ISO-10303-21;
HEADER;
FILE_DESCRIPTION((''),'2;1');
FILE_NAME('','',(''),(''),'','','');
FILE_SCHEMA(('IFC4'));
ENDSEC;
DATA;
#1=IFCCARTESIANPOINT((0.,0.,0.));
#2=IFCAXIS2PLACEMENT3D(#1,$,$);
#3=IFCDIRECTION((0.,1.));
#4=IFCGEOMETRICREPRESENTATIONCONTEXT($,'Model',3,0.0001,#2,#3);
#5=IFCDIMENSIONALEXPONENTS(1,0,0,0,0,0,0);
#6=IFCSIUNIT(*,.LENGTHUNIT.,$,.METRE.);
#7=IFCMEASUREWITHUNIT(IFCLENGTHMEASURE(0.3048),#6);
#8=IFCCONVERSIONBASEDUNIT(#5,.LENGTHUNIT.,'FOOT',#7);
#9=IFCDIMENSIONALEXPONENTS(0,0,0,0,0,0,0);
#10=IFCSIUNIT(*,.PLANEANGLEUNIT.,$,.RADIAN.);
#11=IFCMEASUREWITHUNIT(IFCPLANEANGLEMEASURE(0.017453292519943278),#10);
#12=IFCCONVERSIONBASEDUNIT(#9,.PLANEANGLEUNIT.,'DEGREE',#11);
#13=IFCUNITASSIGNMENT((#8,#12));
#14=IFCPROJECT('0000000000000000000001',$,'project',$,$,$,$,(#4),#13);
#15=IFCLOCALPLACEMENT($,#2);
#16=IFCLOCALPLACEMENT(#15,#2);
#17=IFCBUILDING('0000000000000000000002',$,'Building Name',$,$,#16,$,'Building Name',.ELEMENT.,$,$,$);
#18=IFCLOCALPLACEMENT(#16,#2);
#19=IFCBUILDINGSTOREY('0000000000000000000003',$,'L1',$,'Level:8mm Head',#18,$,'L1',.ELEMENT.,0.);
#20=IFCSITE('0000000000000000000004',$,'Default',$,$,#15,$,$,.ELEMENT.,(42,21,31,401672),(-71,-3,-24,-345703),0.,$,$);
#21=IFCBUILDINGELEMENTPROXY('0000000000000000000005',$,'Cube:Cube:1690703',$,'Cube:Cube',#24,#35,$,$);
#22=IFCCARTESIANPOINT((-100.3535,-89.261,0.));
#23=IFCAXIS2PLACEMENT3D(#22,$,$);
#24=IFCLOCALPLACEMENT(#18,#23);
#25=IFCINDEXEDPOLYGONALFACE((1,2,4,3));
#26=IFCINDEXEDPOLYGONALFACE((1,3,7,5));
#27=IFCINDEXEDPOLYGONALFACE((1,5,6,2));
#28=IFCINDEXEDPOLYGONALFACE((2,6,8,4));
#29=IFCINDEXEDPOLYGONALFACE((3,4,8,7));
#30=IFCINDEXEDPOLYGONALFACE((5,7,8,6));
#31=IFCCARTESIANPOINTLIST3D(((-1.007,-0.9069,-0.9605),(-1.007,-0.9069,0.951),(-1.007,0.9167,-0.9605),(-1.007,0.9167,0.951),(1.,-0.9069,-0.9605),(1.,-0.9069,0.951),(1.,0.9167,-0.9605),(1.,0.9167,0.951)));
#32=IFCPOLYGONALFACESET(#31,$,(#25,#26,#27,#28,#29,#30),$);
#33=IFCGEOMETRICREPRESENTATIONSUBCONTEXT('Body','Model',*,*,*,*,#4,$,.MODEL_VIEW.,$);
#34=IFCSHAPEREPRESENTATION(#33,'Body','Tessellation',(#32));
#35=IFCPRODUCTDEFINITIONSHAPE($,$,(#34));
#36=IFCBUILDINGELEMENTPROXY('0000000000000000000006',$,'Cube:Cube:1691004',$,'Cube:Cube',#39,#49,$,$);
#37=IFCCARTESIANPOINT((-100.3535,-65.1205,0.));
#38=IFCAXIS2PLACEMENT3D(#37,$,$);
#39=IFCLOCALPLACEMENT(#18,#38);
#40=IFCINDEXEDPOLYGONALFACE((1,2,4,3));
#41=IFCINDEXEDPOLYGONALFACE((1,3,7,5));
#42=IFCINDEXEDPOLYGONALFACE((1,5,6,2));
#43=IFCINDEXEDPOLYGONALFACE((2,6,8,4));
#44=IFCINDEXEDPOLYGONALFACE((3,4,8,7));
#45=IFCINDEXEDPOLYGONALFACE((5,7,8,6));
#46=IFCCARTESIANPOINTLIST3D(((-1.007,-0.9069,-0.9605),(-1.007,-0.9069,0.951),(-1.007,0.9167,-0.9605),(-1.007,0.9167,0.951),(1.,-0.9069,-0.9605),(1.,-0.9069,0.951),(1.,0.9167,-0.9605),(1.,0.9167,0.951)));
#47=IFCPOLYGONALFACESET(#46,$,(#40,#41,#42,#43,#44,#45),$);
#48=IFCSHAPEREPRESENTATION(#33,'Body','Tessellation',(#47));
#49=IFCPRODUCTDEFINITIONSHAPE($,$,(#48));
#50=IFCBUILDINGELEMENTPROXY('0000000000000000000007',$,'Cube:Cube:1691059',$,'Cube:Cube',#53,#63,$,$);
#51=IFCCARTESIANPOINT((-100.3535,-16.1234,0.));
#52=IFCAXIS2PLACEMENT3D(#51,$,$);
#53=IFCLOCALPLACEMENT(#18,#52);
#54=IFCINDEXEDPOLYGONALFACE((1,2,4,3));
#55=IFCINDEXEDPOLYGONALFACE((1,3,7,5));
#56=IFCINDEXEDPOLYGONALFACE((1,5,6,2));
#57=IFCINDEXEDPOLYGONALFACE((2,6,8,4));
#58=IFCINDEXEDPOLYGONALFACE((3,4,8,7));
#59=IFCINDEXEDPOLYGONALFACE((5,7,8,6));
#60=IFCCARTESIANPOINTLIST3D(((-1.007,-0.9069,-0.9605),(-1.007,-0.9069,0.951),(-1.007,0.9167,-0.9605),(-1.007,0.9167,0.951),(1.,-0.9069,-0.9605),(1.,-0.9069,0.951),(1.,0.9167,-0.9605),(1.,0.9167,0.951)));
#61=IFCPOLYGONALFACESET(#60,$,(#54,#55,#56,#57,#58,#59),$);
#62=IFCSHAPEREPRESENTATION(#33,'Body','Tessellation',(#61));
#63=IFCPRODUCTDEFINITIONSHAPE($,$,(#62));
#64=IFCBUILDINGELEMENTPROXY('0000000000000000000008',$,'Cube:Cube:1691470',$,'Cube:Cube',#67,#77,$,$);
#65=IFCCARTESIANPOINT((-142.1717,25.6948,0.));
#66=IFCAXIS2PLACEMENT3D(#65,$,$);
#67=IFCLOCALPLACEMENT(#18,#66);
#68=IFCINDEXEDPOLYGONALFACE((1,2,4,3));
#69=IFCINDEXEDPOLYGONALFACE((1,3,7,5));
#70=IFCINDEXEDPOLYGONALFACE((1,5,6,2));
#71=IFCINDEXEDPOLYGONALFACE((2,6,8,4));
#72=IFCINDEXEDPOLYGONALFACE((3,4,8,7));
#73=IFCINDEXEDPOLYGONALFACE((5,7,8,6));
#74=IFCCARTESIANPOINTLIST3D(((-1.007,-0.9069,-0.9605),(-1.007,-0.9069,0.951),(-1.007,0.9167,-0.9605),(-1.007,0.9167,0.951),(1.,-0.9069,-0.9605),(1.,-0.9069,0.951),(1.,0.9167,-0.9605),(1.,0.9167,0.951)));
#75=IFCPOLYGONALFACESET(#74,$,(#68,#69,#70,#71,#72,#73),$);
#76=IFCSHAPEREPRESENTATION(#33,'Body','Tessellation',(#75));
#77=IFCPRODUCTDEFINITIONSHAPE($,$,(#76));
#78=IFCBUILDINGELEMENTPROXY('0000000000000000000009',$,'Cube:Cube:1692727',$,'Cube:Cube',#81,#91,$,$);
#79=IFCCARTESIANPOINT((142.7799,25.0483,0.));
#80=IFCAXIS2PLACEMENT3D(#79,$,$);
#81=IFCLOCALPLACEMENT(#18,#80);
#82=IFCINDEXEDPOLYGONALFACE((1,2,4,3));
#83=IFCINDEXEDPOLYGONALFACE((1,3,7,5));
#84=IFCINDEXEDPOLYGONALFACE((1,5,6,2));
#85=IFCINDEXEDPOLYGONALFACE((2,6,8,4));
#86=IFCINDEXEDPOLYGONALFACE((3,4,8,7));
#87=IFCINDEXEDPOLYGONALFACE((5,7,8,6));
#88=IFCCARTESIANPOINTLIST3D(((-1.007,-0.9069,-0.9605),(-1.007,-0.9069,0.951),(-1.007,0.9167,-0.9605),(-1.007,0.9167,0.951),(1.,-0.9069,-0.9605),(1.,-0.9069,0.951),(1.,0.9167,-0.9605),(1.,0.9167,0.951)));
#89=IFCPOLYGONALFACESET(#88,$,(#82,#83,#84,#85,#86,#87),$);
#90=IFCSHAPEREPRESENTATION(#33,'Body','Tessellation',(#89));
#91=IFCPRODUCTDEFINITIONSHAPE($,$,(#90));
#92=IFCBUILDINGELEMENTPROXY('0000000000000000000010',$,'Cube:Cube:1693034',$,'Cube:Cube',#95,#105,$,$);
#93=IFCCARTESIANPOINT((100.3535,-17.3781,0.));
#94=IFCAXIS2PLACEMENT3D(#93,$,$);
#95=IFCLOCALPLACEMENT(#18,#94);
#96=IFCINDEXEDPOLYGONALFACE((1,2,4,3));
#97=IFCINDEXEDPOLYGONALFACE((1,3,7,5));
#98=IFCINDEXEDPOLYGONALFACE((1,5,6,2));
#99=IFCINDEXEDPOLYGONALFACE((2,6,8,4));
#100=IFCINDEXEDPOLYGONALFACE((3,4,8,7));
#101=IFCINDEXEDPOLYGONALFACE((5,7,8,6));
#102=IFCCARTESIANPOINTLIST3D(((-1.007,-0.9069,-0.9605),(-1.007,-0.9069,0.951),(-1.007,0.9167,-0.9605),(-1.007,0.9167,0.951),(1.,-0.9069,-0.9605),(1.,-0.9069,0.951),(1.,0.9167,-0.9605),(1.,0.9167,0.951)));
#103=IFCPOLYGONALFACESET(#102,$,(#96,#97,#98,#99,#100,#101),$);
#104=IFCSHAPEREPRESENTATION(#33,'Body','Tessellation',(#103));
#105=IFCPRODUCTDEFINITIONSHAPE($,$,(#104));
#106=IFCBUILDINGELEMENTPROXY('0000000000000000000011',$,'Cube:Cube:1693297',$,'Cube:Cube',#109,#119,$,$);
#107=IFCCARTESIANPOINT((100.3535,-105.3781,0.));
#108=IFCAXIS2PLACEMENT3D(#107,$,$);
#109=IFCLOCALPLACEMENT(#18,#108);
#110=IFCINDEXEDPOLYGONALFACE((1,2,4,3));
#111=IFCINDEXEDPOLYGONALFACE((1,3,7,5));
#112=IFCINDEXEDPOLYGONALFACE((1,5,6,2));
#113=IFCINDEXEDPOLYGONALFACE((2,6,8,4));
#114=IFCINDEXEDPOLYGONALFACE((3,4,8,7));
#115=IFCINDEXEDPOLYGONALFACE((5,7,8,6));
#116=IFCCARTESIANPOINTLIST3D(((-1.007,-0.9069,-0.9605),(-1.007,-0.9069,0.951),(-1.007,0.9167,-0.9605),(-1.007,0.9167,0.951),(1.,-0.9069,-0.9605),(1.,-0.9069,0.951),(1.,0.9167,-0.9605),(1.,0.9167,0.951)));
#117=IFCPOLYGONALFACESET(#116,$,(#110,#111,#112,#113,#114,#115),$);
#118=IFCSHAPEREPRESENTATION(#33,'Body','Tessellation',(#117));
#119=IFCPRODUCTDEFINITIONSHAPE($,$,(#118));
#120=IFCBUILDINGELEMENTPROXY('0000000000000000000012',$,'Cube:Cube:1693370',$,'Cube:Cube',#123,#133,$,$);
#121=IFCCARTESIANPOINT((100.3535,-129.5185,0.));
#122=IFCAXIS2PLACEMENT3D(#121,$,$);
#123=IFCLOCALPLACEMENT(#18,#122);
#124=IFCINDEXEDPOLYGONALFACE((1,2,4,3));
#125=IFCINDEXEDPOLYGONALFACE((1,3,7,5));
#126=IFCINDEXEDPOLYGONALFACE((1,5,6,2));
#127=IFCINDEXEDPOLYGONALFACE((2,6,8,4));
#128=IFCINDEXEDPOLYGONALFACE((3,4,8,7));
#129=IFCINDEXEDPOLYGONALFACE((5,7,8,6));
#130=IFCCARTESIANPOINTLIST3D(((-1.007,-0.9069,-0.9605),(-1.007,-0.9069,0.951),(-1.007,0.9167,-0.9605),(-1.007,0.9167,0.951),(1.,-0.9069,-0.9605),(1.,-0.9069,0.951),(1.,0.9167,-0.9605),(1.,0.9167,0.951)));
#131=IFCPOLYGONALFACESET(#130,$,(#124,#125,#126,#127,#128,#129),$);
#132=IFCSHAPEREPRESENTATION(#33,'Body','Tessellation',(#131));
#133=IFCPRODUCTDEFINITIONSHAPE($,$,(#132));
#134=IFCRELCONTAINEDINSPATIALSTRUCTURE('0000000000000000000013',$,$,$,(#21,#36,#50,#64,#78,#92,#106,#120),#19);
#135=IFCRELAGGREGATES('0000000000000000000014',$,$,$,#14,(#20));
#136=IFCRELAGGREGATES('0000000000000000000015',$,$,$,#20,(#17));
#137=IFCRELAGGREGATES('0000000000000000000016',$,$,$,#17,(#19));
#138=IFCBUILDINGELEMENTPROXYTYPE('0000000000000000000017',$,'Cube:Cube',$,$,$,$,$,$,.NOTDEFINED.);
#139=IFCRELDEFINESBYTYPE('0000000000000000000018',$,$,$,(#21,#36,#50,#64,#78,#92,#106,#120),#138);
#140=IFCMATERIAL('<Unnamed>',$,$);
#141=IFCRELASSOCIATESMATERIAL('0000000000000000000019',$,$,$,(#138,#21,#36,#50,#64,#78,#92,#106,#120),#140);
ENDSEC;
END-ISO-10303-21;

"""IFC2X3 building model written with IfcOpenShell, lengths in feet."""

from ifc_helpers import new_model, entity, si_unit, converted_unit, direction, frame, frame_2d, origin, place, context, subcontext, project, spatial, rectangle, extrude, source, transform, mapped, material, type_object, type_shapes, element, save


model = new_model("IFC2X3")

# Units and contexts
model_context = context("Model", 3, precision=0.0001, world=origin(), true_north=direction((0.0, 1.0)))
body_context = subcontext(model_context, "Body", "Model", "MODEL_VIEW")
ifc_project = project(units=[converted_unit("LENGTHUNIT", "FOOT", entity("IfcLengthMeasure", 0.3048), si_unit("LENGTHUNIT", "METRE"), dimensions=[1, 0, 0, 0, 0, 0, 0]), converted_unit("PLANEANGLEUNIT", "DEGREE", entity("IfcPlaneAngleMeasure", 0.017453292519943278), si_unit("PLANEANGLEUNIT", "RADIAN"), dimensions=[0, 0, 0, 0, 0, 0, 0])], contexts=[model_context])

# Site, building, storey
site_placement = place(None, origin())
site = spatial("IfcSite", under=ifc_project, at=site_placement, Name="Default", CompositionType="ELEMENT", RefLatitude=(42, 21, 31, 401672), RefLongitude=(-71, -3, -24, -345703), RefElevation=0.0)
building_placement = place(site_placement, origin())
building = spatial("IfcBuilding", under=site, at=building_placement, Name="Building Name", LongName="Building Name", CompositionType="ELEMENT")
storey_placement = place(building_placement, origin())
storey = spatial("IfcBuildingStorey", under=building, at=storey_placement, Name="L1", ObjectType="Level:8mm Head", LongName="L1", CompositionType="ELEMENT", Elevation=0.0)

# Building element proxies
ifc_material_1 = material(Name="<Unnamed>")
building_element_proxy_type = type_object("IfcBuildingElementProxyType", Name="Cube:Cube", PredefinedType="NOTDEFINED", material=ifc_material_1)
shared_shape = source(origin(), body_context, "Body", "SweptSolid", [
    extrude(rectangle(XDim=1.8235, YDim=2.007, at=frame_2d((0.0, 0.0), x_axis=(1.0, 0.0))), frame((-0.0035, 0.0049, -0.9605), z_axis=(0.0, 0.0, 1.0), x_axis=(0.0, 1.0, 0.0)), (0.0, 0.0, 1.0), 1.9115),
])
type_shapes(building_element_proxy_type, [shared_shape])
for number, where, name in (
    (1, (-100.3535, -89.261, 0.0), "Cube:Cube:1690703"),
    (2, (-100.3535, -65.1205, 0.0), "Cube:Cube:1691004"),
    (3, (-100.3535, -16.1234, 0.0), "Cube:Cube:1691059"),
    (4, (-142.1717, 25.6948, 0.0), "Cube:Cube:1691470"),
    (5, (142.7799, 25.0483, 0.0), "Cube:Cube:1692727"),
    (6, (100.3535, -17.3781, 0.0), "Cube:Cube:1693034"),
    (7, (100.3535, -105.3781, 0.0), "Cube:Cube:1693297"),
    (8, (100.3535, -129.5185, 0.0), "Cube:Cube:1693370"),
):
    element("IfcBuildingElementProxy", number, at=place(storey_placement, frame(where)), inside=storey, type_object=building_element_proxy_type, material=ifc_material_1, Name=name, ObjectType="Cube:Cube", context=body_context, shape_type="MappedRepresentation", body=[
        mapped(shared_shape, transform((0.0, 0.0, 0.0), scale=1.0)),
    ])

save(model, "model.ifc")
